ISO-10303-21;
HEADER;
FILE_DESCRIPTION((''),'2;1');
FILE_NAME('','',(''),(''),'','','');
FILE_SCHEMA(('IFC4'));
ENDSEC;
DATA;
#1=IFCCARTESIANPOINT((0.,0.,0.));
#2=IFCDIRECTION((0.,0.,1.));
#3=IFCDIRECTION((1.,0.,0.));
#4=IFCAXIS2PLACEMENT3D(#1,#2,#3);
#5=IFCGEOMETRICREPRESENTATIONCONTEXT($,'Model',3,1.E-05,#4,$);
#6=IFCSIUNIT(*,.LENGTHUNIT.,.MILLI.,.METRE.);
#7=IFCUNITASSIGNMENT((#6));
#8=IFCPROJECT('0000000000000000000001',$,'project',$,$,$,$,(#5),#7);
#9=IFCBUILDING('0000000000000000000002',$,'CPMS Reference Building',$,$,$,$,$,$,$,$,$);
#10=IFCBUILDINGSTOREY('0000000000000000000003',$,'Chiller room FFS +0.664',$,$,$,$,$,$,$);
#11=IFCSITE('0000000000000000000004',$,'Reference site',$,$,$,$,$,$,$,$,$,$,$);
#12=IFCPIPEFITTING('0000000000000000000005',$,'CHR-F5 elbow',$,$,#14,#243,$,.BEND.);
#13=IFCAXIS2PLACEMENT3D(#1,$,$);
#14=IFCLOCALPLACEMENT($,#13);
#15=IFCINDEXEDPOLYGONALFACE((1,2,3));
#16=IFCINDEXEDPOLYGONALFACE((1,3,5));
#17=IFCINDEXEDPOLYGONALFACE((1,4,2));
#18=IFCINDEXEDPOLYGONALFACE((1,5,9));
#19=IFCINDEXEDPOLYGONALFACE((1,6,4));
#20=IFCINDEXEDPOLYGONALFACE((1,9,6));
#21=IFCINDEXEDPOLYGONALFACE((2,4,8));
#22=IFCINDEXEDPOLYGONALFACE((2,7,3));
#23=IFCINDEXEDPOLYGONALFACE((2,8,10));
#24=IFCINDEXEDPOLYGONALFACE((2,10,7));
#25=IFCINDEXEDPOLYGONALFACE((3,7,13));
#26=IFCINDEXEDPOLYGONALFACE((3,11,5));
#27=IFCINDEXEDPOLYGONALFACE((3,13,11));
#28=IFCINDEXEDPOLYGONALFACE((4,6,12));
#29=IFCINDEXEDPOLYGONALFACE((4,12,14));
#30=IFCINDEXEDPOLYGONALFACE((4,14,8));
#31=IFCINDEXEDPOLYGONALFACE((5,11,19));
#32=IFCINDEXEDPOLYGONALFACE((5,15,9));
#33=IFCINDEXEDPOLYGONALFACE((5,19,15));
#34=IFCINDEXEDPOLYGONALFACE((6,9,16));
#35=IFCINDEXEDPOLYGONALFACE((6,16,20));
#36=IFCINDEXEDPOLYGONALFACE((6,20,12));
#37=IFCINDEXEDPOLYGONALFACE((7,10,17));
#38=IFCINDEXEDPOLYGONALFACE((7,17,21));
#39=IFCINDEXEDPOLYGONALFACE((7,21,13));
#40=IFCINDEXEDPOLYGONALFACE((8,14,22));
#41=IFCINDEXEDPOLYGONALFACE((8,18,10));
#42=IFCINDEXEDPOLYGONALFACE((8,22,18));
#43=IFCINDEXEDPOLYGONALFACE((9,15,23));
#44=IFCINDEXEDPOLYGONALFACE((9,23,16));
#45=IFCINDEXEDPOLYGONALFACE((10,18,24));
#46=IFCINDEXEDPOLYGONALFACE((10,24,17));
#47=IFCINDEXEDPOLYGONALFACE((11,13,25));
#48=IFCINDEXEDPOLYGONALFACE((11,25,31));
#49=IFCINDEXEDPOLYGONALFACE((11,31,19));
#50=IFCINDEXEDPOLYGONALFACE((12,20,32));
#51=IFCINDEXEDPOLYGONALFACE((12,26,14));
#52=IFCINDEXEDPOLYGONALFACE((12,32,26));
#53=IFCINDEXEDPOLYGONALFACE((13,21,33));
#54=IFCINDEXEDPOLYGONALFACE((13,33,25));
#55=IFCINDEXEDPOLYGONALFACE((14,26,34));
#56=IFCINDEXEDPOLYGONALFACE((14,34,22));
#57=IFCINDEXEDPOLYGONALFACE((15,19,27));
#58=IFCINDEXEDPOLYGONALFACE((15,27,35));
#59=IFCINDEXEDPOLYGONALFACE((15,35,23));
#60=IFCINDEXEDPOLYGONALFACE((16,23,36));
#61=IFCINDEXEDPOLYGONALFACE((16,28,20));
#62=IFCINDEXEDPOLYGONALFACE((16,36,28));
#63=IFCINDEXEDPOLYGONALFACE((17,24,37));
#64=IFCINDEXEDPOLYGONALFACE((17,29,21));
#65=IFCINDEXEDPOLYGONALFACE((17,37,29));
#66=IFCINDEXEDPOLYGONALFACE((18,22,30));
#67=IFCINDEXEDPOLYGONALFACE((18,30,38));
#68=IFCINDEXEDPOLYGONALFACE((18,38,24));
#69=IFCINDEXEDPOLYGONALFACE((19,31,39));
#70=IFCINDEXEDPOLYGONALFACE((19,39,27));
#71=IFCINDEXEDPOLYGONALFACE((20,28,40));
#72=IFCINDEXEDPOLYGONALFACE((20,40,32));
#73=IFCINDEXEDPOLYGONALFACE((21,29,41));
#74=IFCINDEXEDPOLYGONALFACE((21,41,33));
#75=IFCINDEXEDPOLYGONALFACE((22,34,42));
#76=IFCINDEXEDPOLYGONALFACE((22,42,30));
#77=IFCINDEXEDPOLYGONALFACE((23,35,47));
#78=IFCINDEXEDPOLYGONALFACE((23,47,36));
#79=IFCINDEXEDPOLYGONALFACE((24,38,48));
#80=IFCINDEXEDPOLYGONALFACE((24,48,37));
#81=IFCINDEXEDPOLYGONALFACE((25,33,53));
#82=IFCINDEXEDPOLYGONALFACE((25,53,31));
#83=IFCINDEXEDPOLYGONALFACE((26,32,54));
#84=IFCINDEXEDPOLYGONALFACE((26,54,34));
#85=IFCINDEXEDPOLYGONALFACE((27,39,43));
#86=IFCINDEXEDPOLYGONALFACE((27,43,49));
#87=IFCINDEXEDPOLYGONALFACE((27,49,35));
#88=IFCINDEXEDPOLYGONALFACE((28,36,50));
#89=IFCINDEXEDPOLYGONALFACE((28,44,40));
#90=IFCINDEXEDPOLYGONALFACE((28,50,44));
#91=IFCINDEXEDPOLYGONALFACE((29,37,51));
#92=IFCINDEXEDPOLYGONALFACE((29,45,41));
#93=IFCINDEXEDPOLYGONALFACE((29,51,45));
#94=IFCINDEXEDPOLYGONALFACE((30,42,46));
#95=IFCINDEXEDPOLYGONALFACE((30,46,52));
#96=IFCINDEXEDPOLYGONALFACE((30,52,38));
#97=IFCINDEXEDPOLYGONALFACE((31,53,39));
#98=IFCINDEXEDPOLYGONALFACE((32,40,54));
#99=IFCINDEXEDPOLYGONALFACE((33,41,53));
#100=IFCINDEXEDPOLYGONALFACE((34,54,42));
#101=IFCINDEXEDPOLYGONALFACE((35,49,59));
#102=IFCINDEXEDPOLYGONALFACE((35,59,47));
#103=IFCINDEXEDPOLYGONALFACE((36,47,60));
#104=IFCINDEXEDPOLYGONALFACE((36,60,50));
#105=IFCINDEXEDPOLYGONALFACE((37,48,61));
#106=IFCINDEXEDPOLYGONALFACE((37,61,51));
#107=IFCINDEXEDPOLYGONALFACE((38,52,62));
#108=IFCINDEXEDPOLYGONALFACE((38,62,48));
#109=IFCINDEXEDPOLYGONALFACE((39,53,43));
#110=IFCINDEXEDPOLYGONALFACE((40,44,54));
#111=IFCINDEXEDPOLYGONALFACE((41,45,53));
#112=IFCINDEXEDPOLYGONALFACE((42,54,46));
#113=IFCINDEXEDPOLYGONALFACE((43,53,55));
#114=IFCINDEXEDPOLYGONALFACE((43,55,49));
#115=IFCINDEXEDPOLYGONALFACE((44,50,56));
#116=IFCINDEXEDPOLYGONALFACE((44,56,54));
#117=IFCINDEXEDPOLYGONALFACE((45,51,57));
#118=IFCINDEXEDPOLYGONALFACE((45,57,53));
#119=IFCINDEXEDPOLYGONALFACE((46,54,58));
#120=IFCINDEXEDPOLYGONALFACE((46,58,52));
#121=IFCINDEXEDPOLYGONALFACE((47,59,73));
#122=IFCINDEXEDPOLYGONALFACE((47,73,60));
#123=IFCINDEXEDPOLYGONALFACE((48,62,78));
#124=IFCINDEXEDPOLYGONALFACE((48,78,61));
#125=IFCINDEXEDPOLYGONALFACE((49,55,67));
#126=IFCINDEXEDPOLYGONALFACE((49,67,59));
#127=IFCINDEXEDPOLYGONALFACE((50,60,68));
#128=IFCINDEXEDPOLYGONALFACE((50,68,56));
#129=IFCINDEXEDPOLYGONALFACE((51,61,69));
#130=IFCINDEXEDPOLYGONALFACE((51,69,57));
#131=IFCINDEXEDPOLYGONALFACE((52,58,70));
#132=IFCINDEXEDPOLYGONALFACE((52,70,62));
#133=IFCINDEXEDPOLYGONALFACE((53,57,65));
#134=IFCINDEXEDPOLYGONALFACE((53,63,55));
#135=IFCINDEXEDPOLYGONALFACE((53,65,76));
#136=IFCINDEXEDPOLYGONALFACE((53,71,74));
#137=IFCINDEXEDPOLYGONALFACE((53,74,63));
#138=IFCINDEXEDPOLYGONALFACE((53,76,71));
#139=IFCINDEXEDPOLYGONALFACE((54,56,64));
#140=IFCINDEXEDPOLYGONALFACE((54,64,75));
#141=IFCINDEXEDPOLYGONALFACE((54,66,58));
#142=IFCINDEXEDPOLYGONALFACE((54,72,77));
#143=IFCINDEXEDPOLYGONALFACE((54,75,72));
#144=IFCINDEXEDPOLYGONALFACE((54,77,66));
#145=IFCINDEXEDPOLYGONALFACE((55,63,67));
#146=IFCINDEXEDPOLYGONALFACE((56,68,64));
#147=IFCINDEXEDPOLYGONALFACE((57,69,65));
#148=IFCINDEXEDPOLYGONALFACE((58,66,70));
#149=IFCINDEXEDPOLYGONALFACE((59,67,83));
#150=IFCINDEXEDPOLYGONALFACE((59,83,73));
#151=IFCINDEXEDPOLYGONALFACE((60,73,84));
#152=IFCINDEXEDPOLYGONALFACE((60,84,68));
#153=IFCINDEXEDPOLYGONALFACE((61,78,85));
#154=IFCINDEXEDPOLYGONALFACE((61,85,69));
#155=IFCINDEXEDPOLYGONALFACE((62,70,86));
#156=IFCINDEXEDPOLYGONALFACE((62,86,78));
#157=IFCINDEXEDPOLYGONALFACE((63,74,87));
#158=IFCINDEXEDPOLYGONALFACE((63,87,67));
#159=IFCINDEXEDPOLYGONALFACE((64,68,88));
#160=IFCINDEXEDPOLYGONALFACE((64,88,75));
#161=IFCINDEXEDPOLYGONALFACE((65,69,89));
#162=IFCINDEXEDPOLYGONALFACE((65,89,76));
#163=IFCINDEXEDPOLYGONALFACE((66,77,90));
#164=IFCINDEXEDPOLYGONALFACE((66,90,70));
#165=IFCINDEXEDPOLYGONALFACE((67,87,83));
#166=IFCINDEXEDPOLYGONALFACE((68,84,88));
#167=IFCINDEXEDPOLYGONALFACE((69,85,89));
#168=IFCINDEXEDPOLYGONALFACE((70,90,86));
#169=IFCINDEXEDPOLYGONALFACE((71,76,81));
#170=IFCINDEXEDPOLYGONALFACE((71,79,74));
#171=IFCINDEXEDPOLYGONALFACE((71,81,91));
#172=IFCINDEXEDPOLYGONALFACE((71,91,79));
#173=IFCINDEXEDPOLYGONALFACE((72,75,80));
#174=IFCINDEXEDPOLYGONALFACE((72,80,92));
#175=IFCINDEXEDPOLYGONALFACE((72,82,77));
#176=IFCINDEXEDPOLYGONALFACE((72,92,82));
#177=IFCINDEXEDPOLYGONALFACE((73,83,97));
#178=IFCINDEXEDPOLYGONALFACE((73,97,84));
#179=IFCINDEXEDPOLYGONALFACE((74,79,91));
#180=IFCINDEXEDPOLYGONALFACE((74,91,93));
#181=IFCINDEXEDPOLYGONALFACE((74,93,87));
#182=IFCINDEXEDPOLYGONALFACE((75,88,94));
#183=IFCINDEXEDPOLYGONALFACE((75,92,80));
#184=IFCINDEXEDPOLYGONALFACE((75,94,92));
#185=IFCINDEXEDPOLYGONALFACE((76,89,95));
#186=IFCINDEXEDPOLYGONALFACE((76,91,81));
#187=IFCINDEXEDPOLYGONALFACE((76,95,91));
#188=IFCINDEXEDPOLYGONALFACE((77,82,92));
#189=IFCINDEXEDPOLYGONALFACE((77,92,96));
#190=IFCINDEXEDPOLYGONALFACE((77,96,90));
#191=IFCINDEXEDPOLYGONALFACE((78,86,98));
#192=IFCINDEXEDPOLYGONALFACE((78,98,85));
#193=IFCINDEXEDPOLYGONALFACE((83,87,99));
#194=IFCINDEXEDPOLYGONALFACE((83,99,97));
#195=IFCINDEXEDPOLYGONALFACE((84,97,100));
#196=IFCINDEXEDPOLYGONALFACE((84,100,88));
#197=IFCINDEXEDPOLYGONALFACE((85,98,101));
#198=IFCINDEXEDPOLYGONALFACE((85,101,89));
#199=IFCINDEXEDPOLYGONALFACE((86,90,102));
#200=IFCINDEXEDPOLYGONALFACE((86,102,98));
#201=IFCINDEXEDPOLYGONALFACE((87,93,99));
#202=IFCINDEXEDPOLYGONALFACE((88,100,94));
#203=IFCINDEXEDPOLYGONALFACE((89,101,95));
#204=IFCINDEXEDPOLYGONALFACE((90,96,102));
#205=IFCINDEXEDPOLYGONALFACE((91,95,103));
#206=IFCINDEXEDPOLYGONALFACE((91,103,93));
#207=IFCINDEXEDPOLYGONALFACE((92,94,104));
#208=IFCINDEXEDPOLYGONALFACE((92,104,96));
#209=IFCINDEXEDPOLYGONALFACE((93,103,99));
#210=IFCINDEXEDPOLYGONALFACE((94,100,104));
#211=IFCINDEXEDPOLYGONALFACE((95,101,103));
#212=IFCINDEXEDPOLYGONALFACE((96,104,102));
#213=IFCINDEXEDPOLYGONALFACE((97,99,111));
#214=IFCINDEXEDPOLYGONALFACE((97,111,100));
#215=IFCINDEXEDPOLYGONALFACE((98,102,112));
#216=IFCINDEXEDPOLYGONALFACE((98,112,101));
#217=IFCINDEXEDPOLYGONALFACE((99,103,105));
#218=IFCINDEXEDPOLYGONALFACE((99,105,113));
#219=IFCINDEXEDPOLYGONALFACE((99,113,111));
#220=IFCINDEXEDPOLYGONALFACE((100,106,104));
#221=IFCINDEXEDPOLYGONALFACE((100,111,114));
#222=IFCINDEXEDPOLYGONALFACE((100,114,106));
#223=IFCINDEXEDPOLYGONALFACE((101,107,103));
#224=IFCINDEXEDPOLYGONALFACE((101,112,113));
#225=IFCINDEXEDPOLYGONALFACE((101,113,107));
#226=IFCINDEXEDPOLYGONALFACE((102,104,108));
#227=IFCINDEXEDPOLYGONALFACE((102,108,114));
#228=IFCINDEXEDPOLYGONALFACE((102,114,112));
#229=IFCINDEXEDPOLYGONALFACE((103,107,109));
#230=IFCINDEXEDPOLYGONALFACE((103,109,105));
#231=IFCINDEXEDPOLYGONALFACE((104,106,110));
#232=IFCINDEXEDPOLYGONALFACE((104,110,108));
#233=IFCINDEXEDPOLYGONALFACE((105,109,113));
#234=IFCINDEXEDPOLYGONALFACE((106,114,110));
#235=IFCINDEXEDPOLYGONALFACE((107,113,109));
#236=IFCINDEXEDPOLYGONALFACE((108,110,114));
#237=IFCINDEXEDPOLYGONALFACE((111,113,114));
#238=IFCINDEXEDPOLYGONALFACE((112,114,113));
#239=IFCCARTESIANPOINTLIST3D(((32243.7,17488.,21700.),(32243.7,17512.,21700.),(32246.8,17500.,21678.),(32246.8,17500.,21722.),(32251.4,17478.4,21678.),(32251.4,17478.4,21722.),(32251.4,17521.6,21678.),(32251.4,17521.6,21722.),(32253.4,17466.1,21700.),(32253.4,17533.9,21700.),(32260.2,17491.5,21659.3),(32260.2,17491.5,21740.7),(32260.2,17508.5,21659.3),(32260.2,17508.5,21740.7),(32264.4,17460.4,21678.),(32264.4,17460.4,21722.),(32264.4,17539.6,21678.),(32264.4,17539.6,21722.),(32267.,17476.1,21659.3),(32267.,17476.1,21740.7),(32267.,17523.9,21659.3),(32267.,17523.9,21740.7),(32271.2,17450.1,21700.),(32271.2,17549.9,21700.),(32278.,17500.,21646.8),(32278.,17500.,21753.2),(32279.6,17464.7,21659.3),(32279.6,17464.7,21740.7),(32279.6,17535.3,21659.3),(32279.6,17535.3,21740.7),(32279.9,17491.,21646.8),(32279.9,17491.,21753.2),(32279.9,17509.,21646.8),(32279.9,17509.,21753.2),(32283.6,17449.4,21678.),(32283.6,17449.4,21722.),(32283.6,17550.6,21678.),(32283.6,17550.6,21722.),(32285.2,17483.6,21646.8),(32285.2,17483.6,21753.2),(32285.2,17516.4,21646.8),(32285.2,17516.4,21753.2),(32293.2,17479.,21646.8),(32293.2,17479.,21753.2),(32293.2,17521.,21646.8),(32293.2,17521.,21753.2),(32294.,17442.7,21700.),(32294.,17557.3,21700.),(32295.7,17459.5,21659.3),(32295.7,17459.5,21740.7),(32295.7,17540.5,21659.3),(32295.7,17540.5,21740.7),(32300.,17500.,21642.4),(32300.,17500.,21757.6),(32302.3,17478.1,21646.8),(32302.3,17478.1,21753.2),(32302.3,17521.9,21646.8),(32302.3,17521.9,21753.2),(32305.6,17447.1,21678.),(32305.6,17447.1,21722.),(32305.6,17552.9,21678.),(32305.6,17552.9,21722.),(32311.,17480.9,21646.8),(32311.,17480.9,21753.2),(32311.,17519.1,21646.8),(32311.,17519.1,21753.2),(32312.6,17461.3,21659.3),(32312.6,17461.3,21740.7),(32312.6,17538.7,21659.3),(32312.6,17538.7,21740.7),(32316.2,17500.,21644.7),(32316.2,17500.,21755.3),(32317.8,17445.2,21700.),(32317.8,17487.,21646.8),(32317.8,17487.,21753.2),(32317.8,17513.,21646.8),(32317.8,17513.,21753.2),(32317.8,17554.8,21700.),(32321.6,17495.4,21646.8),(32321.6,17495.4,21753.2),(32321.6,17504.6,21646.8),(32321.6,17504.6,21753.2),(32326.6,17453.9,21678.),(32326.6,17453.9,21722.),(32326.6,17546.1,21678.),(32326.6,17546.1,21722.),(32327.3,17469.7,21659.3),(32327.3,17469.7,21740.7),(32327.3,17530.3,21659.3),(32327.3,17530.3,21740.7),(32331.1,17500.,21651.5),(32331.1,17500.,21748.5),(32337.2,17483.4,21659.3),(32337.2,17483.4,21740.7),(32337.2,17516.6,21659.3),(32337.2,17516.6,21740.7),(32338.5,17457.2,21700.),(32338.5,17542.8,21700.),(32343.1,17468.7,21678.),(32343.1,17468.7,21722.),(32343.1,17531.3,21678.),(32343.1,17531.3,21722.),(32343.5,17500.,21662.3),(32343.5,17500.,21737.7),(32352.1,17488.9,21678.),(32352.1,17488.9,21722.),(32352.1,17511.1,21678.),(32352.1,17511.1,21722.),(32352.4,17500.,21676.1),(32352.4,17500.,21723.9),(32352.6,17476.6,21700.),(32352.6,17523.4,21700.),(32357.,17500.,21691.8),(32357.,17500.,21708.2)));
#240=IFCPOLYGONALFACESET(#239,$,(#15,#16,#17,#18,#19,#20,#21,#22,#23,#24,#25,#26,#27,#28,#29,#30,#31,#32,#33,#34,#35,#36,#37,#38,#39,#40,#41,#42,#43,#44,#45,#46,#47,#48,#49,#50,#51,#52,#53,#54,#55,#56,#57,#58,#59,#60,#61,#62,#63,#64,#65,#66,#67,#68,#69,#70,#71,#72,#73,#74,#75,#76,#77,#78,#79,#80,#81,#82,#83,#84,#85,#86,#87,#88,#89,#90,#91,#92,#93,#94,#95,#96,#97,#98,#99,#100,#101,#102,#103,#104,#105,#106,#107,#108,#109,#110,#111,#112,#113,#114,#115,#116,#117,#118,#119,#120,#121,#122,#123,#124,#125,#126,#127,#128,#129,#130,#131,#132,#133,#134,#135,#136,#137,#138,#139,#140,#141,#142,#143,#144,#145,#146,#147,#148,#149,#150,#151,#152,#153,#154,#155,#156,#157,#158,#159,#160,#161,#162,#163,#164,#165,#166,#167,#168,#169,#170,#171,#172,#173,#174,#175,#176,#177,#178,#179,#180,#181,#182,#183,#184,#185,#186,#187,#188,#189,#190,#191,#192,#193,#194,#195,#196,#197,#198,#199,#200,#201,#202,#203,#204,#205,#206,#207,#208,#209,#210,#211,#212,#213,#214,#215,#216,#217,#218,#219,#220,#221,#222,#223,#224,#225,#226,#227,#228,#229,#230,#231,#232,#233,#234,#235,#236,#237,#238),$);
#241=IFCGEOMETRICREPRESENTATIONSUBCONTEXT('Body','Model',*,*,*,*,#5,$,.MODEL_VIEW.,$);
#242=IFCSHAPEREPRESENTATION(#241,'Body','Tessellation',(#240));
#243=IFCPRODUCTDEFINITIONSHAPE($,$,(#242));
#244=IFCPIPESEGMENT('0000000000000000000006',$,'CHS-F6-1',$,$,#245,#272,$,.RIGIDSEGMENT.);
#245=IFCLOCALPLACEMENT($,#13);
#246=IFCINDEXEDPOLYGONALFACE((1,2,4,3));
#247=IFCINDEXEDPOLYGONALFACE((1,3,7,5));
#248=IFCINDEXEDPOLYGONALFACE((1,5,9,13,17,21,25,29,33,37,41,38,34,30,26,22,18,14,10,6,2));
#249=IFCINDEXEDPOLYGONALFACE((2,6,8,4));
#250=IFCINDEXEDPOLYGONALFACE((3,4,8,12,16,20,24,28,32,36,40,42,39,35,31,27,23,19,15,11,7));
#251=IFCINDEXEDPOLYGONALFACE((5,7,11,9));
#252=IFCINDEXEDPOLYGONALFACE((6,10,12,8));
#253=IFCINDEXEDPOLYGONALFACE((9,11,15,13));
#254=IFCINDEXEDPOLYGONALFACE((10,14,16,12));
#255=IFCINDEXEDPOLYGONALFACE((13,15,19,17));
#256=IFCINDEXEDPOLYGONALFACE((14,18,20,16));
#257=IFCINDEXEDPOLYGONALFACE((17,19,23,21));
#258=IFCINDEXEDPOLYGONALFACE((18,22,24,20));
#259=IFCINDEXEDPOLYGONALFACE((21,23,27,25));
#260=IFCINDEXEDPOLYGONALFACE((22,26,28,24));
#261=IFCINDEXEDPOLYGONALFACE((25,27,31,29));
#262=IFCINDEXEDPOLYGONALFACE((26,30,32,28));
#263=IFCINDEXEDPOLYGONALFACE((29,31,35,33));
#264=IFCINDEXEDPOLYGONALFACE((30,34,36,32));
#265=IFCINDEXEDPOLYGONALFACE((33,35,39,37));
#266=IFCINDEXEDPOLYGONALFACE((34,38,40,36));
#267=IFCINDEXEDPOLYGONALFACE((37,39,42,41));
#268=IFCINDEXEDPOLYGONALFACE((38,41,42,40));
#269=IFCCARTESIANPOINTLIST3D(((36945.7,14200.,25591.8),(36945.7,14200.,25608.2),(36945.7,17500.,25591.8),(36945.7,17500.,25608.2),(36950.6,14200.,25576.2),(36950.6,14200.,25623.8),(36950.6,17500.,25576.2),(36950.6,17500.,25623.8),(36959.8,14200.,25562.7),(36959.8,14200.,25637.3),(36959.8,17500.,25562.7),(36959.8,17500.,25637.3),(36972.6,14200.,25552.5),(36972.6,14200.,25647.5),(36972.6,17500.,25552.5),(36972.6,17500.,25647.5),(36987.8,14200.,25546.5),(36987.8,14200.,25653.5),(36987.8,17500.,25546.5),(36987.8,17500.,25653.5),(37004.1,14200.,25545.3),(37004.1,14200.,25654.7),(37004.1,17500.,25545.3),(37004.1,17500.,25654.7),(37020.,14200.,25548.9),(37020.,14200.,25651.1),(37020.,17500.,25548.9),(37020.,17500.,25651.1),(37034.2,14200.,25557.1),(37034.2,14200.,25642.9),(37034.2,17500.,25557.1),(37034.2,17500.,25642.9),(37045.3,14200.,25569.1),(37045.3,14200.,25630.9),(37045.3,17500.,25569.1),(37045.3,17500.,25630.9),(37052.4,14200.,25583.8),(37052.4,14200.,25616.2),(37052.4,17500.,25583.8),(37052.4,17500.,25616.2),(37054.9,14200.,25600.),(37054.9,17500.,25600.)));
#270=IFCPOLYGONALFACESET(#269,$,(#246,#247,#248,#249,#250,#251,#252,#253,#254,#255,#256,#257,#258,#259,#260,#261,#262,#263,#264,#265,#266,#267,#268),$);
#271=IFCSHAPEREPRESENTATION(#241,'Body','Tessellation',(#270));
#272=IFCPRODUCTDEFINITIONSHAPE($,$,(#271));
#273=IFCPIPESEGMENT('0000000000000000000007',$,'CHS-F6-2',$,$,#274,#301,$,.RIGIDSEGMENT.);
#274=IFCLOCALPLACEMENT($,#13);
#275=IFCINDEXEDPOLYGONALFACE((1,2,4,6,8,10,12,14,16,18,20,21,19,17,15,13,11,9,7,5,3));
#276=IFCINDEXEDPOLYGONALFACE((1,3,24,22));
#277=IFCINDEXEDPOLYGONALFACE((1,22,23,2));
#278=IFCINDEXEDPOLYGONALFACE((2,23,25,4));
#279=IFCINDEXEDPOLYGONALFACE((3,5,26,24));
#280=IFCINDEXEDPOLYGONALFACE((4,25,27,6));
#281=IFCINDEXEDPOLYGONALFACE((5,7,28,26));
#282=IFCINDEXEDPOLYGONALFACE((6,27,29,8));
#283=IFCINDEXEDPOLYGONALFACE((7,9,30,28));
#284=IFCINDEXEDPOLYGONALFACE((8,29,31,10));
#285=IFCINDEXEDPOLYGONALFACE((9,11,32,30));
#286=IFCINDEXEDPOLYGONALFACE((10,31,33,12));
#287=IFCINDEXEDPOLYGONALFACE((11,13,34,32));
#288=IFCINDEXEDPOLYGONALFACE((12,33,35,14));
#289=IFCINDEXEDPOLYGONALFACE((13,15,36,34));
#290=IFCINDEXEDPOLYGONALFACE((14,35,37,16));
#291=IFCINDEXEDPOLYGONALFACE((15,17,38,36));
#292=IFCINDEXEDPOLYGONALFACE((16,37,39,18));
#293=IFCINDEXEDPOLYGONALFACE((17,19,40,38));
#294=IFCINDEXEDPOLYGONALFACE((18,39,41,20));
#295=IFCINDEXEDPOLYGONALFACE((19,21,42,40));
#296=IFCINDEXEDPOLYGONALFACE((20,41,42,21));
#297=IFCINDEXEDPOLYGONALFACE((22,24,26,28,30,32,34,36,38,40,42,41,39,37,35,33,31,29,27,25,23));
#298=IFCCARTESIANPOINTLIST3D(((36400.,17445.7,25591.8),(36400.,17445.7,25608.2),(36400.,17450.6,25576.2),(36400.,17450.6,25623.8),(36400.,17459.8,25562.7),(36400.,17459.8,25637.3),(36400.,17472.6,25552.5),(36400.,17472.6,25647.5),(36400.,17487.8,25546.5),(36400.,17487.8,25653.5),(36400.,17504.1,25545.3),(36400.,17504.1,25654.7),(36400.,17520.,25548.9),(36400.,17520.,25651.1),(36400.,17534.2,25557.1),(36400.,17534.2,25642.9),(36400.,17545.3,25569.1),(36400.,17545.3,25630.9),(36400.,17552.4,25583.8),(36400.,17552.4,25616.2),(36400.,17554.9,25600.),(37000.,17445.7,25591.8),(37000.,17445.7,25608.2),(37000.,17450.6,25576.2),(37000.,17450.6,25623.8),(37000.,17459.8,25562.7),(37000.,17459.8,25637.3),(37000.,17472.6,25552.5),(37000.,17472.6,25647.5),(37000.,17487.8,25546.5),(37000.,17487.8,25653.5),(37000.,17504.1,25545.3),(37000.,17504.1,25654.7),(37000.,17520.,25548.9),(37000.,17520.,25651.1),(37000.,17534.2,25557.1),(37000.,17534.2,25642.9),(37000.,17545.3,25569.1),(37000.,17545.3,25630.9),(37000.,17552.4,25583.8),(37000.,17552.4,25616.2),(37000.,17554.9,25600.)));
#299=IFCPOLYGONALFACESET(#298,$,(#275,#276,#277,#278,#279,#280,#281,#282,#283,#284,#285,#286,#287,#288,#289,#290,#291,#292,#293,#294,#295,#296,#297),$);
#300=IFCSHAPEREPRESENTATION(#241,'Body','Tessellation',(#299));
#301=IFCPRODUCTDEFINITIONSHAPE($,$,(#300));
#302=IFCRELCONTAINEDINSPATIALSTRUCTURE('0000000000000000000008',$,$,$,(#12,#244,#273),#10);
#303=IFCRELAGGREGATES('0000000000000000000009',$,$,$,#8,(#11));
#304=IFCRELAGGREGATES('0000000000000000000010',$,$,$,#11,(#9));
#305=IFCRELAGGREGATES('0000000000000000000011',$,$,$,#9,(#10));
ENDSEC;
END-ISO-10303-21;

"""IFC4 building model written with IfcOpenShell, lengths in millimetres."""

from ifc_helpers import new_model, entity, si_unit, frame, origin_with_axes, origin_2d, place, context, subcontext, project, spatial, circle_curve, outline, extrude, element, save


model = new_model("IFC4")

# Units and contexts
model_context = context("Model", 3, precision=1e-05, world=origin_with_axes())
body_context = subcontext(model_context, "Body", "Model", "MODEL_VIEW")
ifc_project = project(units=[si_unit("LENGTHUNIT", "METRE", prefix="MILLI")], contexts=[model_context])

# Site, building, storey
site = spatial("IfcSite", under=ifc_project, Name="Reference site")
building = spatial("IfcBuilding", under=site, Name="CPMS Reference Building")
storey = spatial("IfcBuildingStorey", under=building, Name="Chiller room FFS +0.664")

# Pipe fitting
pipe_fitting_1_placement = place(None, origin_with_axes())
element("IfcPipeFitting", 1, at=pipe_fitting_1_placement, inside=storey, Name="CHR-F5 elbow", PredefinedType="BEND", context=body_context, shape_type="CSG", body=[
    entity("IfcSphere", entity("IfcAxis2Placement3D", entity("IfcCartesianPoint", [32300.0, 17500.0, 21700.0]), entity("IfcDirection", [0.0, 0.0, 1.0]), entity("IfcDirection", [1.0, 0.0, 0.0])), 57.6),
])

# Pipe segments
pipe_segment_1_placement = place(None, origin_with_axes())
element("IfcPipeSegment", 2, at=pipe_segment_1_placement, inside=storey, Name="CHS-F6-1", PredefinedType="RIGIDSEGMENT", context=body_context, shape_type="SweptSolid", body=[
    extrude(outline(circle_curve(origin_2d(), 54.9)), frame((37000.0, 14200.0, 25600.0), z_axis=(0.0, 1.0, 0.0), x_axis=(1.0, 0.0, 0.0)), (0.0, 0.0, 1.0), 3300.0),
])
pipe_segment_2_placement = place(None, origin_with_axes())
element("IfcPipeSegment", 3, at=pipe_segment_2_placement, inside=storey, Name="CHS-F6-2", PredefinedType="RIGIDSEGMENT", context=body_context, shape_type="SweptSolid", body=[
    extrude(outline(circle_curve(origin_2d(), 54.9)), frame((37000.0, 17500.0, 25600.0), z_axis=(-1.0, 0.0, 0.0), x_axis=(0.0, 1.0, 0.0)), (0.0, 0.0, 1.0), 600.0),
])

save(model, "model.ifc")
